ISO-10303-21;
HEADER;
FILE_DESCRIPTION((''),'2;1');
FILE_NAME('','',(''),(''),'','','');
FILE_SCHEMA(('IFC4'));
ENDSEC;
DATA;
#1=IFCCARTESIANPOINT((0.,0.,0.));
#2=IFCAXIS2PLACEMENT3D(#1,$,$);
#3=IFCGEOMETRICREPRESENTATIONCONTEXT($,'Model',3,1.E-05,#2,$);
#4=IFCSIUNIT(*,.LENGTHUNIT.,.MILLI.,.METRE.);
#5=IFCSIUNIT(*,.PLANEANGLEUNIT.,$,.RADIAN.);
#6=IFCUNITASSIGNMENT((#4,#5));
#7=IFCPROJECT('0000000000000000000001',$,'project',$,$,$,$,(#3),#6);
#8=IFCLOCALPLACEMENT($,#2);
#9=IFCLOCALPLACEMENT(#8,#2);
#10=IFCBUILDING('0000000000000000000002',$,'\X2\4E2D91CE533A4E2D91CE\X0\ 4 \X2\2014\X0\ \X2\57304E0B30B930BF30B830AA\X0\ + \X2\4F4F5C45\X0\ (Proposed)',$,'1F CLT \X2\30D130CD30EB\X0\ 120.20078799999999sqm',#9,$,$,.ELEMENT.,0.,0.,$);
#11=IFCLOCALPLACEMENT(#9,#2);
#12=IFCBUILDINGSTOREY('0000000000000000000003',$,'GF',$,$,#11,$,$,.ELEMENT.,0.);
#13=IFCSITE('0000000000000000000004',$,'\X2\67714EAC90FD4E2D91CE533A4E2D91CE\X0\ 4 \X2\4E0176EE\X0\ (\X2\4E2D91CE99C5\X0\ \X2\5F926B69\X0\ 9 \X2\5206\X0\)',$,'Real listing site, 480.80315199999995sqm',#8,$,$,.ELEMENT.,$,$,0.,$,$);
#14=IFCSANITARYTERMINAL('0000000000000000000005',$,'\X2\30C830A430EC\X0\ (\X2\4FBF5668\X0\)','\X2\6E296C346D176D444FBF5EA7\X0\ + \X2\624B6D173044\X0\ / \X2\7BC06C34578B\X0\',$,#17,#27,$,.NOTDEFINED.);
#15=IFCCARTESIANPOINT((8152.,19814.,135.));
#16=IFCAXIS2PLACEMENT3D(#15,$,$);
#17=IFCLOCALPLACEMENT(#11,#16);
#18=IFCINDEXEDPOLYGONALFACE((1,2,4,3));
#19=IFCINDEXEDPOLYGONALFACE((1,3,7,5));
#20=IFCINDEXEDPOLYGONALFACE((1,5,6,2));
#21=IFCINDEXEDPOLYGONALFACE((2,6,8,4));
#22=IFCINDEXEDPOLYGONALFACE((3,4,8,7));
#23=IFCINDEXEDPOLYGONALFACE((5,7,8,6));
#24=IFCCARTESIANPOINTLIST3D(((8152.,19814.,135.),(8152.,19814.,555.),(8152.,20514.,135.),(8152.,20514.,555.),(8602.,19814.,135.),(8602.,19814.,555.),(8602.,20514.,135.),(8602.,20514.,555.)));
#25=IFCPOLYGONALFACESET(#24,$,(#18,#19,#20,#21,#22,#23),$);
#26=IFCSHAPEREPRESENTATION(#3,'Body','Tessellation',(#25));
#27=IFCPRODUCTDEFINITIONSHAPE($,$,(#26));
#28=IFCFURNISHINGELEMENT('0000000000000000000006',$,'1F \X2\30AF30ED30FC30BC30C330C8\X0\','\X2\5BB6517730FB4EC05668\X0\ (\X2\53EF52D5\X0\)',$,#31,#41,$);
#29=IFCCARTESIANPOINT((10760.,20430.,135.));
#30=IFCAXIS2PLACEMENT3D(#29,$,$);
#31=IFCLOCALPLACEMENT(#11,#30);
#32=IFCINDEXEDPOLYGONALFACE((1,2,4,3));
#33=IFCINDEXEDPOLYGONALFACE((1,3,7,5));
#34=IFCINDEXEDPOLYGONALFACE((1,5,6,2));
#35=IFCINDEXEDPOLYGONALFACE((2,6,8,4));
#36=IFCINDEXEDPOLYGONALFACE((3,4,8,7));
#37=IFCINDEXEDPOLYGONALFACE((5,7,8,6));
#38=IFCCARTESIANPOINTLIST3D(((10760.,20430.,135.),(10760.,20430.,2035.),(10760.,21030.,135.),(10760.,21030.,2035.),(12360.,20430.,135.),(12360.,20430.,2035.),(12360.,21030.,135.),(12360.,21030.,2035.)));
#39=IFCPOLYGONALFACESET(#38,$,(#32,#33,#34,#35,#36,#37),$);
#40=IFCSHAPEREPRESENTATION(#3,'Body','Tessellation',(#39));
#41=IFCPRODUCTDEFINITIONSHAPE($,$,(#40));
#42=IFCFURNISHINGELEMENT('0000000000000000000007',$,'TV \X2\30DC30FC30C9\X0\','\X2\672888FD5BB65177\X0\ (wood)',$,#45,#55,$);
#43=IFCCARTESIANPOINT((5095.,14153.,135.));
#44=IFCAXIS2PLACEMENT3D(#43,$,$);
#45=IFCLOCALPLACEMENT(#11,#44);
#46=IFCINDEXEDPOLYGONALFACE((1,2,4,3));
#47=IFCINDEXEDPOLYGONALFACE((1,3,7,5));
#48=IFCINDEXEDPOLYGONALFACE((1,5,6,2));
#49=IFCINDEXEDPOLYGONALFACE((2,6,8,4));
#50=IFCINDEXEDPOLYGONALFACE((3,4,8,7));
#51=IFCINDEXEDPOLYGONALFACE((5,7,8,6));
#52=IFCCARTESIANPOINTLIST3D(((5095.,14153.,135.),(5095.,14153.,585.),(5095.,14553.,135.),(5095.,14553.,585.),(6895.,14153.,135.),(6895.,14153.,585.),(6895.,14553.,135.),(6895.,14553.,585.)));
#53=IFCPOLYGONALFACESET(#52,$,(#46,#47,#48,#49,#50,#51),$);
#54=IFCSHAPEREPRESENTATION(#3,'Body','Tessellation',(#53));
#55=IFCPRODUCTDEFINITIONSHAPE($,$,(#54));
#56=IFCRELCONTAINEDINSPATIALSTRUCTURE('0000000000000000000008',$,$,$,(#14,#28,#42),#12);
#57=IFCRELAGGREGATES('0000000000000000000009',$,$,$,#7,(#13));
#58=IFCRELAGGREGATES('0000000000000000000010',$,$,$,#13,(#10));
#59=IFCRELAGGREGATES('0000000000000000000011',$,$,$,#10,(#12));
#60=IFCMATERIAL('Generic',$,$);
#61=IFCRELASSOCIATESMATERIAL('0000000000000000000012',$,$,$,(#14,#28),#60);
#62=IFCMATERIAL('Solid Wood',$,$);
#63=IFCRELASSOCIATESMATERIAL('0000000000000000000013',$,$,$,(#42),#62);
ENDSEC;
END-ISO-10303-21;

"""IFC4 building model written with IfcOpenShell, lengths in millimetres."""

from ifc_helpers import new_model, si_unit, frame, frame_2d, origin, place, context, project, spatial, rectangle, extrude, material, element, save


model = new_model("IFC4")

# Units and contexts
model_context = context("Model", 3, precision=1e-05, world=origin())
ifc_project = project(units=[si_unit("LENGTHUNIT", "METRE", prefix="MILLI"), si_unit("PLANEANGLEUNIT", "RADIAN")], contexts=[model_context])

# Site, building, storey
site_placement = place(None, origin())
site = spatial("IfcSite", under=ifc_project, at=site_placement, Name="東京都中野区中野 4 丁目 (中野駅 徒歩 9 分)", ObjectType="Real listing site, 480.80315199999995sqm", CompositionType="ELEMENT", RefElevation=0.0)
building_placement = place(site_placement, origin())
building = spatial("IfcBuilding", under=site, at=building_placement, Name="中野区中野 4 — 地下スタジオ + 住居 (Proposed)", ObjectType="1F CLT パネル 120.20078799999999sqm", CompositionType="ELEMENT", ElevationOfRefHeight=0.0, ElevationOfTerrain=0.0)
storey_placement = place(building_placement, origin())
storey = spatial("IfcBuildingStorey", under=building, at=storey_placement, Name="GF", CompositionType="ELEMENT", Elevation=0.0)

# Shared definitions
ifc_material_1 = material(Name="Solid Wood")

# Sanitary terminal
ifc_material_2 = material(Name="Generic")
sanitary_terminal_1_placement = place(storey_placement, frame((8152.0, 19814.0, 135.0)))
element("IfcSanitaryTerminal", 1, at=sanitary_terminal_1_placement, inside=storey, material=ifc_material_2, Name="トイレ (便器)", Description="温水洗浄便座 + 手洗い / 節水型", PredefinedType="NOTDEFINED", context=model_context, shape_type="SweptSolid", body=[
    extrude(rectangle(XDim=450.0, YDim=700.0, at=frame_2d((225.0, 350.0))), frame((8152.0, 19814.0, 135.0)), (0.0, 0.0, 1.0), 420.0),
])

# Furnishing elements
furnishing_1_placement = place(storey_placement, frame((10760.0, 20430.0, 135.0)))
element("IfcFurnishingElement", 2, at=furnishing_1_placement, inside=storey, material=ifc_material_2, Name="1F クローゼット", Description="家具・什器 (可動)", context=model_context, shape_type="SweptSolid", body=[
    extrude(rectangle(XDim=1600.0, YDim=600.0, at=frame_2d((800.0, 300.0))), frame((10760.0, 20430.0, 135.0)), (0.0, 0.0, 1.0), 1900.0),
])
furnishing_2_placement = place(storey_placement, frame((5095.0, 14153.0, 135.0)))
element("IfcFurnishingElement", 3, at=furnishing_2_placement, inside=storey, material=ifc_material_1, Name="TV ボード", Description="木製家具 (wood)", context=model_context, shape_type="SweptSolid", body=[
    extrude(rectangle(XDim=1800.0, YDim=400.0, at=frame_2d((900.0, 200.0))), frame((5095.0, 14153.0, 135.0)), (0.0, 0.0, 1.0), 450.0),
])

save(model, "model.ifc")
